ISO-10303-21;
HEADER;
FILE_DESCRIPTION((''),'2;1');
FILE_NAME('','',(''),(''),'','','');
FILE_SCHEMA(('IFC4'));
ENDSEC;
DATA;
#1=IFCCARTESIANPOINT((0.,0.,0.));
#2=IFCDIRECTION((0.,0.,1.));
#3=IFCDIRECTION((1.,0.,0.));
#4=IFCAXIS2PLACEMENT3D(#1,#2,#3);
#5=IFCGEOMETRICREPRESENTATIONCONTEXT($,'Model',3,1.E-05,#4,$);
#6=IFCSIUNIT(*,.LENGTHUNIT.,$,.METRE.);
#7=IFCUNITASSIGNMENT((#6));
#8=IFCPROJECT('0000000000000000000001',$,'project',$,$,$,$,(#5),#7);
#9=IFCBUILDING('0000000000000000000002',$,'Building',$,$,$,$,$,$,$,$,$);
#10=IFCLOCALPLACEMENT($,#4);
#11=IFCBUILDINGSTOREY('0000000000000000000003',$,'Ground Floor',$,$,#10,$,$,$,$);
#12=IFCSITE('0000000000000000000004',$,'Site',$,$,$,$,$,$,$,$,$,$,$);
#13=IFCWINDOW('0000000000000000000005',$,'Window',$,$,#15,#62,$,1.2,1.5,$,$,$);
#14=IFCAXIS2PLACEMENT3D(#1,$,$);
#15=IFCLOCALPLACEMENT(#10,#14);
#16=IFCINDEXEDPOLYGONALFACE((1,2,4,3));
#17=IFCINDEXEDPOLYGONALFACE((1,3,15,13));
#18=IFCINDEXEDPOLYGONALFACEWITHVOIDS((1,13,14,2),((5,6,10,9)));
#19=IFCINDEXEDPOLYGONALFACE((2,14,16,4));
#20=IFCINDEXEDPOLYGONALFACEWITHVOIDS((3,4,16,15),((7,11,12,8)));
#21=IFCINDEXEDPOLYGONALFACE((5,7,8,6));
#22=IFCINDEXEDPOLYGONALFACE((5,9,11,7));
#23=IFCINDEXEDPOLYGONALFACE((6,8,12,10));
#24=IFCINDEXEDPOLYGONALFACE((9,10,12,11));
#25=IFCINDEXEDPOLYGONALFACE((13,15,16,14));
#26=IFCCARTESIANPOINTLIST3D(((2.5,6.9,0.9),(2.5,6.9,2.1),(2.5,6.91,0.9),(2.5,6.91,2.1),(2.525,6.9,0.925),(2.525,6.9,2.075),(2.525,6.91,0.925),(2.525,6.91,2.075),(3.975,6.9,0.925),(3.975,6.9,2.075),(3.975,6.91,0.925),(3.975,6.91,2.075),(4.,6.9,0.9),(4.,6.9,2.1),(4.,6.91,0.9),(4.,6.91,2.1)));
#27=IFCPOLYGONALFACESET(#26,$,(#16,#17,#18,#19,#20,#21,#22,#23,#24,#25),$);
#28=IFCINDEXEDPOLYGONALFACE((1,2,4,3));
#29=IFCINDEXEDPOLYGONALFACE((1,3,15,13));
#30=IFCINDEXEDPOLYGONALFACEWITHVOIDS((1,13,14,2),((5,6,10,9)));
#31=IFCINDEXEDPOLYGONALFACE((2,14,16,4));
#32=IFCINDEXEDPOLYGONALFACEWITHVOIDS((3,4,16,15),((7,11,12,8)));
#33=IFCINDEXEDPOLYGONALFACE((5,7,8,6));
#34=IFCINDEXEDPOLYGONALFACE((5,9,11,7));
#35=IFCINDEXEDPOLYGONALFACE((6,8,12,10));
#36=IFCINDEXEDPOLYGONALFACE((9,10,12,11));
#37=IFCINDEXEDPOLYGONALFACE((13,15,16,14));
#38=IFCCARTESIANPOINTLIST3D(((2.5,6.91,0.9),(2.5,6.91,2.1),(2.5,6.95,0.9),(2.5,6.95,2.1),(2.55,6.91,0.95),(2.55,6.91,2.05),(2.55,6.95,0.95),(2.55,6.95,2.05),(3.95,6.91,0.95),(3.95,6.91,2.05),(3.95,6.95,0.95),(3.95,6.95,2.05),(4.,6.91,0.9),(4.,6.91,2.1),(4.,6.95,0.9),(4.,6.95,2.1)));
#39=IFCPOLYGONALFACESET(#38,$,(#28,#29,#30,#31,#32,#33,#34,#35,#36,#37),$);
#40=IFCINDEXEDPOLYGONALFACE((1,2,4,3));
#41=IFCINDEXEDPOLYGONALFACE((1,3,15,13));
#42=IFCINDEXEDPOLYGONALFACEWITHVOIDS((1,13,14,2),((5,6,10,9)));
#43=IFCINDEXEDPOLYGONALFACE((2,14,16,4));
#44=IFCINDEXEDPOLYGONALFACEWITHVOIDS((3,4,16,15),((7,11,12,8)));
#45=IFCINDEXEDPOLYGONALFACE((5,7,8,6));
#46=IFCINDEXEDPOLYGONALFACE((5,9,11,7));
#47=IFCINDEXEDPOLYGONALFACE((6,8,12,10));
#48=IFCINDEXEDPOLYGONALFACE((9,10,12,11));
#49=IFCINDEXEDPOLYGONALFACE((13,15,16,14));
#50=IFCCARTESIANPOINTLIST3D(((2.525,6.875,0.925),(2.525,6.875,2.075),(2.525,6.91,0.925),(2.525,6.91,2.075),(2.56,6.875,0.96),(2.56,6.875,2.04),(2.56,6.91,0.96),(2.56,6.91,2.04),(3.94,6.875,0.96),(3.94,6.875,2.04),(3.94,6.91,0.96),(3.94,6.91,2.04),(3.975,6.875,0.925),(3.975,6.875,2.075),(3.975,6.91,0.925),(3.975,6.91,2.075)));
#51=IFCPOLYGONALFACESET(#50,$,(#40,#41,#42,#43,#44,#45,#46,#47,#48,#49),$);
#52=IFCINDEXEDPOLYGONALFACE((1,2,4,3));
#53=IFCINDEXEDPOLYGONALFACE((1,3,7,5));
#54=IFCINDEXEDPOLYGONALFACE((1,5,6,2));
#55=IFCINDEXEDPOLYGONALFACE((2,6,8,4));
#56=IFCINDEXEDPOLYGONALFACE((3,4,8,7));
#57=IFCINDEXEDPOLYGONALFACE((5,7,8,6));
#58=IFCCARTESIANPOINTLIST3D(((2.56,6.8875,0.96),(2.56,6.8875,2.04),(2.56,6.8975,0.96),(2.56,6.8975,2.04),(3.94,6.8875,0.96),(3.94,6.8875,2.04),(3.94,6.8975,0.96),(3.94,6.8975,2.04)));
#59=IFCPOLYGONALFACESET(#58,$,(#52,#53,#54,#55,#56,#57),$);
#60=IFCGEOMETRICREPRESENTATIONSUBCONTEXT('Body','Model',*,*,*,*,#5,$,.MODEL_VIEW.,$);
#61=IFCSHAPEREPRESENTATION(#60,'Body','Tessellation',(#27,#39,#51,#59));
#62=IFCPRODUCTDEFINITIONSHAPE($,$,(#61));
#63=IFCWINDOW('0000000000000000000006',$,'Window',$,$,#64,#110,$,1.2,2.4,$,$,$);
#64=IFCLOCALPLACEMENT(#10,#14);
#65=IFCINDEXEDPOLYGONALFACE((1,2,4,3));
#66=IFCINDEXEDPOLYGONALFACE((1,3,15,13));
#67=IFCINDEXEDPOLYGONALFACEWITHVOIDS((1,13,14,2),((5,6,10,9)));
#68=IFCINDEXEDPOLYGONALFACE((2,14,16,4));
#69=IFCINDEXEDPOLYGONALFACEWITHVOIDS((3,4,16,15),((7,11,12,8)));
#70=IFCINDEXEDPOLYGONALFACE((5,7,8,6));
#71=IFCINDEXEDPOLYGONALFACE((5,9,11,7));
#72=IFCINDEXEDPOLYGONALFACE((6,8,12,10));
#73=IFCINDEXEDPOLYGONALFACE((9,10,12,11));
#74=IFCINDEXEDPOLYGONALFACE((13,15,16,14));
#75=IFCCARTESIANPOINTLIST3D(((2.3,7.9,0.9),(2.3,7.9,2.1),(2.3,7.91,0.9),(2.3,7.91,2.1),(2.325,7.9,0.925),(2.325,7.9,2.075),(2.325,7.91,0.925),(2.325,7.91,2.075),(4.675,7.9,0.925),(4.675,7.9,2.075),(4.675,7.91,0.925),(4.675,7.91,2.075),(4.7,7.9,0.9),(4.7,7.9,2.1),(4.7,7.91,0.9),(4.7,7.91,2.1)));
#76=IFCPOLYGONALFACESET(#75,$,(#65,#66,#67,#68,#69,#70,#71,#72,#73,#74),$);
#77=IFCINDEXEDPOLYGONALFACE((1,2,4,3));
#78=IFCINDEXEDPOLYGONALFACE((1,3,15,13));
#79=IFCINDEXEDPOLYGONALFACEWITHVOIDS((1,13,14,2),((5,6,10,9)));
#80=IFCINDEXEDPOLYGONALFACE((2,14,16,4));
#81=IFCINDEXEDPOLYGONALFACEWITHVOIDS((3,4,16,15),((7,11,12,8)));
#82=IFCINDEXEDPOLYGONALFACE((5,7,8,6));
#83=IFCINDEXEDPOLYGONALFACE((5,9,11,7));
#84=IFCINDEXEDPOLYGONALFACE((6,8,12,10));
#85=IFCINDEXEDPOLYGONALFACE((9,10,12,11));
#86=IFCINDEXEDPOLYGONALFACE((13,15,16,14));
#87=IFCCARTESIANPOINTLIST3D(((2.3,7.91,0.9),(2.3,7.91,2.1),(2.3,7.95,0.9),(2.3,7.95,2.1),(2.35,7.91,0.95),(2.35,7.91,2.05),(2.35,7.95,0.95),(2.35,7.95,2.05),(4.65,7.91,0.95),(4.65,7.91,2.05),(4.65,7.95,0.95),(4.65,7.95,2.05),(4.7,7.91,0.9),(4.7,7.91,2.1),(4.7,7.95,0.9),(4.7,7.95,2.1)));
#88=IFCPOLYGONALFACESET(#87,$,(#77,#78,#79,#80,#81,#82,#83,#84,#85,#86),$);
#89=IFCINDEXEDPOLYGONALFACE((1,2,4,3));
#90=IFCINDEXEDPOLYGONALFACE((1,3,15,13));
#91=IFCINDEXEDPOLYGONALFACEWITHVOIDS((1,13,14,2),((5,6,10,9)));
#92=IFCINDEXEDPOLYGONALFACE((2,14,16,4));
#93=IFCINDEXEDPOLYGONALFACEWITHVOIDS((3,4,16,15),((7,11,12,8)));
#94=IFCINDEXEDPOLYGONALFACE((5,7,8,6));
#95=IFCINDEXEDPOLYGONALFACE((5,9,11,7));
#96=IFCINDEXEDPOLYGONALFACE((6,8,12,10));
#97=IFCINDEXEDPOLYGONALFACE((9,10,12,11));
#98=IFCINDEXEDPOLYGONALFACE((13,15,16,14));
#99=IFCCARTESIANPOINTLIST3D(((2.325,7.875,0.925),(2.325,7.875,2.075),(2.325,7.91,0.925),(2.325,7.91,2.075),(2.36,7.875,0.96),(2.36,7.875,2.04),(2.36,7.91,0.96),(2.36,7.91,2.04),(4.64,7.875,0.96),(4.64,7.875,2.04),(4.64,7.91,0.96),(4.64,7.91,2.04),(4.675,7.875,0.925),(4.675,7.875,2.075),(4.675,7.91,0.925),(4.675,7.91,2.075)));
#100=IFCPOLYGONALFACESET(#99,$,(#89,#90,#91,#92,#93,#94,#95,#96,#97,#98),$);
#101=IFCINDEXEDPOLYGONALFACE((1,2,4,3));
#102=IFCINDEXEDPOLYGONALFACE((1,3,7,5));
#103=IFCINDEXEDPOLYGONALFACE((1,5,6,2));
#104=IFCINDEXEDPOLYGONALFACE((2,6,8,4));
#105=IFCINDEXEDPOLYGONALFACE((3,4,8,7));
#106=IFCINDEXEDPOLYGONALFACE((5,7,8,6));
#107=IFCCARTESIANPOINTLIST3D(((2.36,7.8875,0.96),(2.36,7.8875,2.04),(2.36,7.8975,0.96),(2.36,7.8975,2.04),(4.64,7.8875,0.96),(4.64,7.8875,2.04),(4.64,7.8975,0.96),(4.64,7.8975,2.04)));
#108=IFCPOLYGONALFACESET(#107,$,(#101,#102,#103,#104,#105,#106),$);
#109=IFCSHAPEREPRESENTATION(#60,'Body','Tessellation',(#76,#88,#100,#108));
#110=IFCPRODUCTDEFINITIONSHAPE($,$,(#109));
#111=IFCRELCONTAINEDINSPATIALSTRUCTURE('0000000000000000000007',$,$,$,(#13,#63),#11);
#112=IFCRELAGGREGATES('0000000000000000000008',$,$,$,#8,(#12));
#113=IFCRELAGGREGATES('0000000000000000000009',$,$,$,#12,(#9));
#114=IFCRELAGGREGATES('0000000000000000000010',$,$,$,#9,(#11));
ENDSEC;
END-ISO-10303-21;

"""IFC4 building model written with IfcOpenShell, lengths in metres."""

from ifc_helpers import new_model, si_unit, frame, origin_with_axes, place, context, subcontext, project, spatial, line, indexed_curve, outline, extrude, element, save


model = new_model("IFC4")

# Units and contexts
model_context = context("Model", 3, precision=1e-05, world=origin_with_axes())
body_context = subcontext(model_context, "Body", "Model", "MODEL_VIEW")
ifc_project = project(units=[si_unit("LENGTHUNIT", "METRE")], contexts=[model_context])

# Site, building, storey
site = spatial("IfcSite", under=ifc_project, Name="Site")
building = spatial("IfcBuilding", under=site, Name="Building")
storey_placement = place(None, origin_with_axes())
storey = spatial("IfcBuildingStorey", under=building, at=storey_placement, Name="Ground Floor")

# Windows
window_1_placement = place(storey_placement, frame((4.0, 7.0, 0.9), z_axis=(0.0, 0.0, 1.0), x_axis=(-1.0, 0.0, 0.0)))
element("IfcWindow", 1, at=window_1_placement, inside=storey, Name="Window", OverallHeight=1.2, OverallWidth=1.5, context=body_context, shape_type="SweptSolid", body=[
    extrude(outline(indexed_curve([(0.0, 0.0), (1.5, 0.0), (1.5, 1.2), (0.0, 1.2)], segments=[line(1, 2, 3, 4, 1)]), holes=[indexed_curve([(0.025, 0.025), (1.475, 0.025), (1.475, 1.175), (0.025, 1.175)], segments=[line(1, 2, 3, 4, 1)])]), frame((0.0, 0.09, 0.0), z_axis=(0.0, -1.0, 0.0), x_axis=(1.0, 0.0, 0.0)), (0.0, 0.0, -1.0), 0.01),
    extrude(outline(indexed_curve([(0.0, 0.0), (1.5, 0.0), (1.5, 1.2), (0.0, 1.2)], segments=[line(1, 2, 3, 4, 1)]), holes=[indexed_curve([(0.05, 0.05), (1.45, 0.05), (1.45, 1.15), (0.05, 1.15)], segments=[line(1, 2, 3, 4, 1)])]), frame((0.0, 0.05, 0.0), z_axis=(0.0, -1.0, 0.0), x_axis=(1.0, 0.0, 0.0)), (0.0, 0.0, -1.0), 0.04),
    extrude(outline(indexed_curve([(0.0, 0.0), (1.45, 0.0), (1.45, 1.15), (0.0, 1.15)], segments=[line(1, 2, 3, 4, 1)]), holes=[indexed_curve([(0.035, 0.035), (1.415, 0.035), (1.415, 1.115), (0.035, 1.115)], segments=[line(1, 2, 3, 4, 1)])]), frame((0.025, 0.09, 0.025), z_axis=(0.0, -1.0, 0.0), x_axis=(1.0, 0.0, 0.0)), (0.0, 0.0, -1.0), 0.035),
    extrude(outline(indexed_curve([(0.035, 0.035), (1.415, 0.035), (1.415, 1.115), (0.035, 1.115)], segments=[line(1, 2, 3, 4, 1)])), frame((0.025, 0.1025, 0.025), z_axis=(0.0, -1.0, 0.0), x_axis=(1.0, 0.0, 0.0)), (0.0, 0.0, -1.0), 0.01),
])
window_2_placement = place(storey_placement, frame((4.7, 8.0, 0.9), z_axis=(0.0, 0.0, 1.0), x_axis=(-1.0, 0.0, 0.0)))
element("IfcWindow", 2, at=window_2_placement, inside=storey, Name="Window", OverallHeight=1.2, OverallWidth=2.4, context=body_context, shape_type="SweptSolid", body=[
    extrude(outline(indexed_curve([(0.0, 0.0), (2.4, 0.0), (2.4, 1.2), (0.0, 1.2)], segments=[line(1, 2, 3, 4, 1)]), holes=[indexed_curve([(0.025, 0.025), (2.375, 0.025), (2.375, 1.175), (0.025, 1.175)], segments=[line(1, 2, 3, 4, 1)])]), frame((0.0, 0.09, 0.0), z_axis=(0.0, -1.0, 0.0), x_axis=(1.0, 0.0, 0.0)), (0.0, 0.0, -1.0), 0.01),
    extrude(outline(indexed_curve([(0.0, 0.0), (2.4, 0.0), (2.4, 1.2), (0.0, 1.2)], segments=[line(1, 2, 3, 4, 1)]), holes=[indexed_curve([(0.05, 0.05), (2.35, 0.05), (2.35, 1.15), (0.05, 1.15)], segments=[line(1, 2, 3, 4, 1)])]), frame((0.0, 0.05, 0.0), z_axis=(0.0, -1.0, 0.0), x_axis=(1.0, 0.0, 0.0)), (0.0, 0.0, -1.0), 0.04),
    extrude(outline(indexed_curve([(0.0, 0.0), (2.35, 0.0), (2.35, 1.15), (0.0, 1.15)], segments=[line(1, 2, 3, 4, 1)]), holes=[indexed_curve([(0.035, 0.035), (2.315, 0.035), (2.315, 1.115), (0.035, 1.115)], segments=[line(1, 2, 3, 4, 1)])]), frame((0.025, 0.09, 0.025), z_axis=(0.0, -1.0, 0.0), x_axis=(1.0, 0.0, 0.0)), (0.0, 0.0, -1.0), 0.035),
    extrude(outline(indexed_curve([(0.035, 0.035), (2.315, 0.035), (2.315, 1.115), (0.035, 1.115)], segments=[line(1, 2, 3, 4, 1)])), frame((0.025, 0.1025, 0.025), z_axis=(0.0, -1.0, 0.0), x_axis=(1.0, 0.0, 0.0)), (0.0, 0.0, -1.0), 0.01),
])

save(model, "model.ifc")
